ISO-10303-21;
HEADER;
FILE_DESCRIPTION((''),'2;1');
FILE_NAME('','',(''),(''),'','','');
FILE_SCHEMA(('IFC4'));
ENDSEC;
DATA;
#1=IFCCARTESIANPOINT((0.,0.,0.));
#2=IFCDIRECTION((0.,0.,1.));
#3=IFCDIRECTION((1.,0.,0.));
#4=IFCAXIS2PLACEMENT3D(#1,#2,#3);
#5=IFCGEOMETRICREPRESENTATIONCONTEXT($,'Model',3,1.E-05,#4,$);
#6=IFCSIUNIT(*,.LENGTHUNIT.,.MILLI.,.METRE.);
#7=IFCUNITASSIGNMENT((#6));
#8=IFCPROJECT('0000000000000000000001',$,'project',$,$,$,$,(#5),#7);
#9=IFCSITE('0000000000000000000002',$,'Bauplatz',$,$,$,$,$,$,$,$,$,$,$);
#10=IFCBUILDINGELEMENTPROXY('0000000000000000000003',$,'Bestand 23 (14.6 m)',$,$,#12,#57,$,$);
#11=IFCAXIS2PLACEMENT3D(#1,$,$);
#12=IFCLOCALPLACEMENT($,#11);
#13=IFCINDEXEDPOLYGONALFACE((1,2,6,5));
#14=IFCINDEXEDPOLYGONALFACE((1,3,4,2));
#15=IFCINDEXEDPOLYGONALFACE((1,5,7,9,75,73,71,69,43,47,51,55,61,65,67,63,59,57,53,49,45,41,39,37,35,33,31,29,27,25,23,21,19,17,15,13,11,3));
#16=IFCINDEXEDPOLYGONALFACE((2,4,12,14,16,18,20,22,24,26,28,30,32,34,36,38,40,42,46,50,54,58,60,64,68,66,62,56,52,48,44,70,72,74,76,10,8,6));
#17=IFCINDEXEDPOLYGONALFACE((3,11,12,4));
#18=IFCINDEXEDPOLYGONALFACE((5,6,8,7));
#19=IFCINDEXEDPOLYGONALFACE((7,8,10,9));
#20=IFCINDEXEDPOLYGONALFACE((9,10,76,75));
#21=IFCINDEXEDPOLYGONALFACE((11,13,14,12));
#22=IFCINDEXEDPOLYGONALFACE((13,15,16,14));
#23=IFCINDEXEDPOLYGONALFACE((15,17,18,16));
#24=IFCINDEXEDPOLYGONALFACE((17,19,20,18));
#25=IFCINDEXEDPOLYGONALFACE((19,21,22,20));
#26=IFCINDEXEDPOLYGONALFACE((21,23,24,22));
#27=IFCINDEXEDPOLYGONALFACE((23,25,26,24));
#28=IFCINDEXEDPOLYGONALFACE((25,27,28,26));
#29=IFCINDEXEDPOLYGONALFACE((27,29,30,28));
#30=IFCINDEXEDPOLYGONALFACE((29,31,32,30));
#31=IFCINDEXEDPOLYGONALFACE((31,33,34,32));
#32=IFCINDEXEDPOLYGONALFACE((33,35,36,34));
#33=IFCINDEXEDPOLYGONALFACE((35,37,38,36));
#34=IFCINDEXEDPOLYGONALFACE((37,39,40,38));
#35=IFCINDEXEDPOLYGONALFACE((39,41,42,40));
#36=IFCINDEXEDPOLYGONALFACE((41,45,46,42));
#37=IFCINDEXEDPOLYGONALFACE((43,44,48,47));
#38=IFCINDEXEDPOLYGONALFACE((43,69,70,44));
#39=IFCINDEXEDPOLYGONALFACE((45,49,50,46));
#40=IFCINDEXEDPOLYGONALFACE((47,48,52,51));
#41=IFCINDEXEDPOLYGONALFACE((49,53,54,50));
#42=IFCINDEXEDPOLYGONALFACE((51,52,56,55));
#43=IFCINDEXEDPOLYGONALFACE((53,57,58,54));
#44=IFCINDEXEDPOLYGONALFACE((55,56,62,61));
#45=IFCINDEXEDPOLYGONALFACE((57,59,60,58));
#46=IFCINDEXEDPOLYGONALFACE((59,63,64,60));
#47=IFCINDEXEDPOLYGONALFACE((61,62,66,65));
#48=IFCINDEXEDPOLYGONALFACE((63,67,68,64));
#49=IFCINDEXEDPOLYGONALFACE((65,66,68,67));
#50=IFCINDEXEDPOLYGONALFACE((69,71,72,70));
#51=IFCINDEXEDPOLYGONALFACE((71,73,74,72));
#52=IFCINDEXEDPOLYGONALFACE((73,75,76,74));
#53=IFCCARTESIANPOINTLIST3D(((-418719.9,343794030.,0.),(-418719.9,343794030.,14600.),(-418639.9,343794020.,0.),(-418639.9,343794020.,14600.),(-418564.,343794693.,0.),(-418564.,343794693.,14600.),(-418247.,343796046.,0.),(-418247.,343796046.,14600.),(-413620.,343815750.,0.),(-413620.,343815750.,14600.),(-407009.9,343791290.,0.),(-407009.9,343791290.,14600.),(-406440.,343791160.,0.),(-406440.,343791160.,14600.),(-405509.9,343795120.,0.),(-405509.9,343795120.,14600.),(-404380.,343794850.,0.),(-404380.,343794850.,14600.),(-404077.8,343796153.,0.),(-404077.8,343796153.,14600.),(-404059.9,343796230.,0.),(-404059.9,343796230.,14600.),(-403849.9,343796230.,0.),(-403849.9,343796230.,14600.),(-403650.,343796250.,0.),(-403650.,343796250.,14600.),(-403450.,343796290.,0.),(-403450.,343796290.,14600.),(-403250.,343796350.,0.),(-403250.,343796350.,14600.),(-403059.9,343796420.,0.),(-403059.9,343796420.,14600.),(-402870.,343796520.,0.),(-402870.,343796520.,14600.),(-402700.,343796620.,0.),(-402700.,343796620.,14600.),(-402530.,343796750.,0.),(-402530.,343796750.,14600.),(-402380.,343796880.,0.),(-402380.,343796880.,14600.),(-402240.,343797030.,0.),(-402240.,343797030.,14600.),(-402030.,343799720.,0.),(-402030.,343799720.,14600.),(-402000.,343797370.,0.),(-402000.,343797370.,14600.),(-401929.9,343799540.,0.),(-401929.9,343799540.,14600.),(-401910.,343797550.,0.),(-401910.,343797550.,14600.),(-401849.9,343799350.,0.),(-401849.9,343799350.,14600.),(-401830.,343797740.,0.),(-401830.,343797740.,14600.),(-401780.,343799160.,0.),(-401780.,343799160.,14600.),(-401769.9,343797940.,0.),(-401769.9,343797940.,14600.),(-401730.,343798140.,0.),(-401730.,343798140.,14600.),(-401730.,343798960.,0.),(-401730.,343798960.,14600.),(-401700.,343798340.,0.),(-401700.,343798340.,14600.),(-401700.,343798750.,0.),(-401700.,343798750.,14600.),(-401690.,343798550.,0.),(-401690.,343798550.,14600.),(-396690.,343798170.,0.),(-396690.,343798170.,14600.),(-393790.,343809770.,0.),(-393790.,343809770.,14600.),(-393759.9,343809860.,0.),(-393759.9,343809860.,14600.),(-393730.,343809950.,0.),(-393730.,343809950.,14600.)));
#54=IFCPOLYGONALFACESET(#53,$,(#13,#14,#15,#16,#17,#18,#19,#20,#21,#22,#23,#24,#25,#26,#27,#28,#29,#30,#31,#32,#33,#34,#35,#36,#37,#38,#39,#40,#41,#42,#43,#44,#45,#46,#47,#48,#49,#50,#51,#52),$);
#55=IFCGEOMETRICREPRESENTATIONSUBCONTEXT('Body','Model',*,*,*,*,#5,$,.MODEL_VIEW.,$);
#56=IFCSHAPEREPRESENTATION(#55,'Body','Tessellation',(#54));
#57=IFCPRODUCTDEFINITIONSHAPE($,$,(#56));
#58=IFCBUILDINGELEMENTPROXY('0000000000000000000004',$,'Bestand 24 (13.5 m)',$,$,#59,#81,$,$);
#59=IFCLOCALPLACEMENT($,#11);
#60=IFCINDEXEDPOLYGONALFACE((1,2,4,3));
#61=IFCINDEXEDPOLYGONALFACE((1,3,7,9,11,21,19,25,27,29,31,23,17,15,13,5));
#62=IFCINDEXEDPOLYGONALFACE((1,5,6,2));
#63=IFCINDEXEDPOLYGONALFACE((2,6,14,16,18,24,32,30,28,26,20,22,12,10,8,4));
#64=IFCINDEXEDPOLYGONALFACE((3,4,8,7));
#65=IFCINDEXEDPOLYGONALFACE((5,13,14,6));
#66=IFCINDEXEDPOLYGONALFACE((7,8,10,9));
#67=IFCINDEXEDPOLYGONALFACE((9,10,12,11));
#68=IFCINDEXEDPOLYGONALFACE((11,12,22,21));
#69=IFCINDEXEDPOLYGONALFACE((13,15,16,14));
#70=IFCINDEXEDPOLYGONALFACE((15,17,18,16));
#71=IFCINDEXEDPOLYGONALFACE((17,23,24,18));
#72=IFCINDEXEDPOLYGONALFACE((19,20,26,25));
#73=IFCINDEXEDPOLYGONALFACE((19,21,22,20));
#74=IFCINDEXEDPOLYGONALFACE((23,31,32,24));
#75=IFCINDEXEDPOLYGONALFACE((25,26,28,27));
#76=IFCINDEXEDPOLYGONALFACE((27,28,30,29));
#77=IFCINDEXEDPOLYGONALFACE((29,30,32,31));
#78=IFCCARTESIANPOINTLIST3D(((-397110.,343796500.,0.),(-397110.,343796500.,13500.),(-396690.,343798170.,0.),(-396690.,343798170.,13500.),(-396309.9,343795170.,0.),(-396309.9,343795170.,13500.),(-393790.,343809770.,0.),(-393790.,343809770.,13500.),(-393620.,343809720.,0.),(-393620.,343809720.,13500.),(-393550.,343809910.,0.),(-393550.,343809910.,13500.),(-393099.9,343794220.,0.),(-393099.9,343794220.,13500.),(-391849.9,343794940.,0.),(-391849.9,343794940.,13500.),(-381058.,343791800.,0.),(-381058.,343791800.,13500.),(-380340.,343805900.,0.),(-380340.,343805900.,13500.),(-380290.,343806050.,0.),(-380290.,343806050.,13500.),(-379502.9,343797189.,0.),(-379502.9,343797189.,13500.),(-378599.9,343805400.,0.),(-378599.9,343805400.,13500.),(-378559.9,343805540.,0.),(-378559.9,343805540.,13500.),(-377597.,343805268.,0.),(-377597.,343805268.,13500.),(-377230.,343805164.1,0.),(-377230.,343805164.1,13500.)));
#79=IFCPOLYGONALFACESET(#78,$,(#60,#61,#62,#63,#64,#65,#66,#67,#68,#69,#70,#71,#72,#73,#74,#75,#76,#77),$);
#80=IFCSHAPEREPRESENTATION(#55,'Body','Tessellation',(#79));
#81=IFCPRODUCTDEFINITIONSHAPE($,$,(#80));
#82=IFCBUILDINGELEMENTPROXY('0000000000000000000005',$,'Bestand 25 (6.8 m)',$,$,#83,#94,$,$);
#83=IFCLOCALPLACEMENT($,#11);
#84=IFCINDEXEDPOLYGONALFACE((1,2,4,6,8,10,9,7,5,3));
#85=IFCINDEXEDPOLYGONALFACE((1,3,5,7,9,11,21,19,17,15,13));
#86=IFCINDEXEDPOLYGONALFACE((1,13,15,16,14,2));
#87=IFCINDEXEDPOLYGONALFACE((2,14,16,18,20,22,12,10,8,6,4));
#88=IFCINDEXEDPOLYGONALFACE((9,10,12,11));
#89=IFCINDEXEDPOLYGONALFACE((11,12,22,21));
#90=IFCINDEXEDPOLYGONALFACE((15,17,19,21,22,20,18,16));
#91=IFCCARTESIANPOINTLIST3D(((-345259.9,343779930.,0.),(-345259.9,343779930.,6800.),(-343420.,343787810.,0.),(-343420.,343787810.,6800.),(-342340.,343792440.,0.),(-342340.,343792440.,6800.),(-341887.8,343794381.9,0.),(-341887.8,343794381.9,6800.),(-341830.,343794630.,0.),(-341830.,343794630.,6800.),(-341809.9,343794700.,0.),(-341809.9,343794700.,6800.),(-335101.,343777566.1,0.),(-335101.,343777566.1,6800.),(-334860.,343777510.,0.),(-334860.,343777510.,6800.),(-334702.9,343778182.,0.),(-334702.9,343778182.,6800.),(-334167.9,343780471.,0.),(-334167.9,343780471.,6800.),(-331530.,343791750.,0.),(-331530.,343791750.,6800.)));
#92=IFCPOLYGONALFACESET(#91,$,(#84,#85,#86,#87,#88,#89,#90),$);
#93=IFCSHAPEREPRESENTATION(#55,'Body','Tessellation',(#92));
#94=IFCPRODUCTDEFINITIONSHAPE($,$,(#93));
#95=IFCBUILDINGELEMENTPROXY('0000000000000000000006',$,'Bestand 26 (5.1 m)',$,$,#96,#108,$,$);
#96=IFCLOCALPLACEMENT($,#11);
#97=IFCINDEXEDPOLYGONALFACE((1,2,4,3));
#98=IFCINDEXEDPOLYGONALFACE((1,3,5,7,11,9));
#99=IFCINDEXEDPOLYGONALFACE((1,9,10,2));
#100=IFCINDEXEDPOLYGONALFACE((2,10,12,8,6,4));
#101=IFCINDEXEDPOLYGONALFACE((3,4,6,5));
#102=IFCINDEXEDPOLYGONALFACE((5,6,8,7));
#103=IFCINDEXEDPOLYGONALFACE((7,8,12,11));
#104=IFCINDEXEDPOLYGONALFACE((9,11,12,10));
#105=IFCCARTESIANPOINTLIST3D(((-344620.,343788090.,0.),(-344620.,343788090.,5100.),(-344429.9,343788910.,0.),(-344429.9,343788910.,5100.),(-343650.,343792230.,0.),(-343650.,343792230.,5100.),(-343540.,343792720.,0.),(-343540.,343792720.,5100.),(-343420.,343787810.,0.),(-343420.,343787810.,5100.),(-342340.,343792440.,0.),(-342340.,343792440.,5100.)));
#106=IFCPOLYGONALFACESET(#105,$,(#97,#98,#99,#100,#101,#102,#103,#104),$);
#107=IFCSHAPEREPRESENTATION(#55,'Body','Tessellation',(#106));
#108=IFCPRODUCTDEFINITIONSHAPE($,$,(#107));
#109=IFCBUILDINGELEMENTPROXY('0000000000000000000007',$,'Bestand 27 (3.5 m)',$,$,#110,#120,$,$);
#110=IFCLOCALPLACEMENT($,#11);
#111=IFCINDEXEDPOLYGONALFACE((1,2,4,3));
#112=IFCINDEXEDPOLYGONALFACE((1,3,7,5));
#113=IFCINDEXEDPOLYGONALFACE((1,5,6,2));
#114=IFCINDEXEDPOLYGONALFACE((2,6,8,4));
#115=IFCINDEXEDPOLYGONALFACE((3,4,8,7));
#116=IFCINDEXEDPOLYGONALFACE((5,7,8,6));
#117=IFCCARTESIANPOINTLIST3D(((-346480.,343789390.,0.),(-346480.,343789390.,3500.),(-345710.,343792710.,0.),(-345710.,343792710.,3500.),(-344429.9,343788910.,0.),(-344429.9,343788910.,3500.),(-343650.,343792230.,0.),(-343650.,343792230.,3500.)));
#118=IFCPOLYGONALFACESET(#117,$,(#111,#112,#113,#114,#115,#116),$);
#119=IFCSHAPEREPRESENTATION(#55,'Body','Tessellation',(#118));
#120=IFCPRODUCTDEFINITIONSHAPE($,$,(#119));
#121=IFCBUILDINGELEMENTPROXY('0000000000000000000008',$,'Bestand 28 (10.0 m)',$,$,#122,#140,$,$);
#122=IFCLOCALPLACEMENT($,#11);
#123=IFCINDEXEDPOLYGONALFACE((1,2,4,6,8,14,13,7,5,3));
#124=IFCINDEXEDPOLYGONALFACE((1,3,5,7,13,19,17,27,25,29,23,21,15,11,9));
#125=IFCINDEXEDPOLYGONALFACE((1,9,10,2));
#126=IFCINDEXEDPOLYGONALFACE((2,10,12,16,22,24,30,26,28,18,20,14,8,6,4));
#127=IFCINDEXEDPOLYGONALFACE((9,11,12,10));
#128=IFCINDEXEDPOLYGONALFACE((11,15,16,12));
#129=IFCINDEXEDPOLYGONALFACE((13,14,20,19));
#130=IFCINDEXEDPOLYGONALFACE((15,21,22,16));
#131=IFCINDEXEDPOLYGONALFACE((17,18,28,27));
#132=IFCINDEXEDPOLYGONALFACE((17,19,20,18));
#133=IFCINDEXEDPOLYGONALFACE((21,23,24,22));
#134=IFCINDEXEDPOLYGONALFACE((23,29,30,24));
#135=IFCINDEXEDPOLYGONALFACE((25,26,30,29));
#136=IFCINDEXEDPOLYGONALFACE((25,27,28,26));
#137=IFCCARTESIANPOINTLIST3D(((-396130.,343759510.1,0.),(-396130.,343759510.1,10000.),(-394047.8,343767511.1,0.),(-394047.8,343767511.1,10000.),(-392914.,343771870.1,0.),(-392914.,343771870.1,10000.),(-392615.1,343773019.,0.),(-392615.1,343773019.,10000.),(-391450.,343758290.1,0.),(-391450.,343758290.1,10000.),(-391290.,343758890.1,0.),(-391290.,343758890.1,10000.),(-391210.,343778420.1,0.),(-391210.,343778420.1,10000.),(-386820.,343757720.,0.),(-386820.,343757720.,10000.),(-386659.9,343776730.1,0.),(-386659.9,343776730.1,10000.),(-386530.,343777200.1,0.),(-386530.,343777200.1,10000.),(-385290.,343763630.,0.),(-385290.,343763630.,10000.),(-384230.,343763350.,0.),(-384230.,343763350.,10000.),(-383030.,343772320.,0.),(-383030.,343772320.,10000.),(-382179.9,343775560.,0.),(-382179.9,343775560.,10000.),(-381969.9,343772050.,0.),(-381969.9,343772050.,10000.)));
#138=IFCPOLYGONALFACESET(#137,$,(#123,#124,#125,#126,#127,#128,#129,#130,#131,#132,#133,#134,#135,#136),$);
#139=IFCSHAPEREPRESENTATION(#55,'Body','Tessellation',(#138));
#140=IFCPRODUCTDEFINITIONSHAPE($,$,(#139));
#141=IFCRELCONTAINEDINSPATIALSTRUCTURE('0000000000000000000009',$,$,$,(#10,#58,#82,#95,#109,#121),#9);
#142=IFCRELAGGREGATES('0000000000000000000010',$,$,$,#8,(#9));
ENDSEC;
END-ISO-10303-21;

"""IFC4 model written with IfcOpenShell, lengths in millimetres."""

from ifc_helpers import new_model, si_unit, origin_with_axes, place, context, subcontext, project, spatial, indexed_curve, outline, extrude, element, save


model = new_model("IFC4")

# Units and contexts
model_context = context("Model", 3, precision=1e-05, world=origin_with_axes())
body_context = subcontext(model_context, "Body", "Model", "MODEL_VIEW")
ifc_project = project(units=[si_unit("LENGTHUNIT", "METRE", prefix="MILLI")], contexts=[model_context])

# Site
site = spatial("IfcSite", under=ifc_project, Name="Bauplatz")

# Building element proxies
proxy_1_placement = place(None, origin_with_axes())
element("IfcBuildingElementProxy", 1, at=proxy_1_placement, inside=site, Name="Bestand 23 (14.6 m)", context=body_context, shape_type="SweptSolid", body=[
    extrude(outline(indexed_curve([(-393730.0, 343809950.0), (-413620.0, 343815750.0), (-418247.0, 343796046.0), (-418564.0, 343794693.0), (-418719.9, 343794030.0), (-418639.9, 343794020.0), (-407009.9, 343791290.0), (-406440.0, 343791160.0), (-405509.9, 343795120.0), (-404380.0, 343794850.0), (-404077.8, 343796153.0), (-404059.9, 343796230.0), (-403849.9, 343796230.0), (-403650.0, 343796250.0), (-403450.0, 343796290.0), (-403250.0, 343796350.0), (-403059.9, 343796420.0), (-402870.0, 343796520.0), (-402700.0, 343796620.0), (-402530.0, 343796750.0), (-402380.0, 343796880.0), (-402240.0, 343797030.0), (-402000.0, 343797370.0), (-401910.0, 343797550.0), (-401830.0, 343797740.0), (-401769.9, 343797940.0), (-401730.0, 343798140.0), (-401700.0, 343798340.0), (-401690.0, 343798550.0), (-401700.0, 343798750.0), (-401730.0, 343798960.0), (-401780.0, 343799160.0), (-401849.9, 343799350.0), (-401929.9, 343799540.0), (-402030.0, 343799720.0), (-396690.0, 343798170.0), (-393790.0, 343809770.0), (-393759.9, 343809860.0)])), None, (0.0, 0.0, 1.0), 14600.0),
])
proxy_2_placement = place(None, origin_with_axes())
element("IfcBuildingElementProxy", 2, at=proxy_2_placement, inside=site, Name="Bestand 24 (13.5 m)", context=body_context, shape_type="SweptSolid", body=[
    extrude(outline(indexed_curve([(-380290.0, 343806050.0), (-393550.0, 343809910.0), (-393620.0, 343809720.0), (-393790.0, 343809770.0), (-396690.0, 343798170.0), (-397110.0, 343796500.0), (-396309.9, 343795170.0), (-393099.9, 343794220.0), (-391849.9, 343794940.0), (-381058.0, 343791800.0), (-379502.9, 343797189.0), (-377230.0, 343805164.1), (-377597.0, 343805268.0), (-378559.9, 343805540.0), (-378599.9, 343805400.0), (-380340.0, 343805900.0)])), None, (0.0, 0.0, 1.0), 13500.0),
])
proxy_3_placement = place(None, origin_with_axes())
element("IfcBuildingElementProxy", 3, at=proxy_3_placement, inside=site, Name="Bestand 25 (6.8 m)", context=body_context, shape_type="SweptSolid", body=[
    extrude(outline(indexed_curve([(-331530.0, 343791750.0), (-341809.9, 343794700.0), (-341830.0, 343794630.0), (-341887.8, 343794381.9), (-342340.0, 343792440.0), (-343420.0, 343787810.0), (-345259.9, 343779930.0), (-335101.0, 343777566.1), (-334860.0, 343777510.0), (-334702.9, 343778182.0), (-334167.9, 343780471.0)])), None, (0.0, 0.0, 1.0), 6800.0),
])
proxy_4_placement = place(None, origin_with_axes())
element("IfcBuildingElementProxy", 4, at=proxy_4_placement, inside=site, Name="Bestand 26 (5.1 m)", context=body_context, shape_type="SweptSolid", body=[
    extrude(outline(indexed_curve([(-342340.0, 343792440.0), (-343540.0, 343792720.0), (-343650.0, 343792230.0), (-344429.9, 343788910.0), (-344620.0, 343788090.0), (-343420.0, 343787810.0)])), None, (0.0, 0.0, 1.0), 5100.0),
])
proxy_5_placement = place(None, origin_with_axes())
element("IfcBuildingElementProxy", 5, at=proxy_5_placement, inside=site, Name="Bestand 27 (3.5 m)", context=body_context, shape_type="SweptSolid", body=[
    extrude(outline(indexed_curve([(-343650.0, 343792230.0), (-345710.0, 343792710.0), (-346480.0, 343789390.0), (-344429.9, 343788910.0)])), None, (0.0, 0.0, 1.0), 3500.0),
])
proxy_6_placement = place(None, origin_with_axes())
element("IfcBuildingElementProxy", 6, at=proxy_6_placement, inside=site, Name="Bestand 28 (10.0 m)", context=body_context, shape_type="SweptSolid", body=[
    extrude(outline(indexed_curve([(-386530.0, 343777200.1), (-391210.0, 343778420.1), (-392615.1, 343773019.0), (-392914.0, 343771870.1), (-394047.8, 343767511.1), (-396130.0, 343759510.1), (-391450.0, 343758290.1), (-391290.0, 343758890.1), (-386820.0, 343757720.0), (-385290.0, 343763630.0), (-384230.0, 343763350.0), (-381969.9, 343772050.0), (-383030.0, 343772320.0), (-382179.9, 343775560.0), (-386659.9, 343776730.1)])), None, (0.0, 0.0, 1.0), 10000.0),
])

save(model, "model.ifc")
